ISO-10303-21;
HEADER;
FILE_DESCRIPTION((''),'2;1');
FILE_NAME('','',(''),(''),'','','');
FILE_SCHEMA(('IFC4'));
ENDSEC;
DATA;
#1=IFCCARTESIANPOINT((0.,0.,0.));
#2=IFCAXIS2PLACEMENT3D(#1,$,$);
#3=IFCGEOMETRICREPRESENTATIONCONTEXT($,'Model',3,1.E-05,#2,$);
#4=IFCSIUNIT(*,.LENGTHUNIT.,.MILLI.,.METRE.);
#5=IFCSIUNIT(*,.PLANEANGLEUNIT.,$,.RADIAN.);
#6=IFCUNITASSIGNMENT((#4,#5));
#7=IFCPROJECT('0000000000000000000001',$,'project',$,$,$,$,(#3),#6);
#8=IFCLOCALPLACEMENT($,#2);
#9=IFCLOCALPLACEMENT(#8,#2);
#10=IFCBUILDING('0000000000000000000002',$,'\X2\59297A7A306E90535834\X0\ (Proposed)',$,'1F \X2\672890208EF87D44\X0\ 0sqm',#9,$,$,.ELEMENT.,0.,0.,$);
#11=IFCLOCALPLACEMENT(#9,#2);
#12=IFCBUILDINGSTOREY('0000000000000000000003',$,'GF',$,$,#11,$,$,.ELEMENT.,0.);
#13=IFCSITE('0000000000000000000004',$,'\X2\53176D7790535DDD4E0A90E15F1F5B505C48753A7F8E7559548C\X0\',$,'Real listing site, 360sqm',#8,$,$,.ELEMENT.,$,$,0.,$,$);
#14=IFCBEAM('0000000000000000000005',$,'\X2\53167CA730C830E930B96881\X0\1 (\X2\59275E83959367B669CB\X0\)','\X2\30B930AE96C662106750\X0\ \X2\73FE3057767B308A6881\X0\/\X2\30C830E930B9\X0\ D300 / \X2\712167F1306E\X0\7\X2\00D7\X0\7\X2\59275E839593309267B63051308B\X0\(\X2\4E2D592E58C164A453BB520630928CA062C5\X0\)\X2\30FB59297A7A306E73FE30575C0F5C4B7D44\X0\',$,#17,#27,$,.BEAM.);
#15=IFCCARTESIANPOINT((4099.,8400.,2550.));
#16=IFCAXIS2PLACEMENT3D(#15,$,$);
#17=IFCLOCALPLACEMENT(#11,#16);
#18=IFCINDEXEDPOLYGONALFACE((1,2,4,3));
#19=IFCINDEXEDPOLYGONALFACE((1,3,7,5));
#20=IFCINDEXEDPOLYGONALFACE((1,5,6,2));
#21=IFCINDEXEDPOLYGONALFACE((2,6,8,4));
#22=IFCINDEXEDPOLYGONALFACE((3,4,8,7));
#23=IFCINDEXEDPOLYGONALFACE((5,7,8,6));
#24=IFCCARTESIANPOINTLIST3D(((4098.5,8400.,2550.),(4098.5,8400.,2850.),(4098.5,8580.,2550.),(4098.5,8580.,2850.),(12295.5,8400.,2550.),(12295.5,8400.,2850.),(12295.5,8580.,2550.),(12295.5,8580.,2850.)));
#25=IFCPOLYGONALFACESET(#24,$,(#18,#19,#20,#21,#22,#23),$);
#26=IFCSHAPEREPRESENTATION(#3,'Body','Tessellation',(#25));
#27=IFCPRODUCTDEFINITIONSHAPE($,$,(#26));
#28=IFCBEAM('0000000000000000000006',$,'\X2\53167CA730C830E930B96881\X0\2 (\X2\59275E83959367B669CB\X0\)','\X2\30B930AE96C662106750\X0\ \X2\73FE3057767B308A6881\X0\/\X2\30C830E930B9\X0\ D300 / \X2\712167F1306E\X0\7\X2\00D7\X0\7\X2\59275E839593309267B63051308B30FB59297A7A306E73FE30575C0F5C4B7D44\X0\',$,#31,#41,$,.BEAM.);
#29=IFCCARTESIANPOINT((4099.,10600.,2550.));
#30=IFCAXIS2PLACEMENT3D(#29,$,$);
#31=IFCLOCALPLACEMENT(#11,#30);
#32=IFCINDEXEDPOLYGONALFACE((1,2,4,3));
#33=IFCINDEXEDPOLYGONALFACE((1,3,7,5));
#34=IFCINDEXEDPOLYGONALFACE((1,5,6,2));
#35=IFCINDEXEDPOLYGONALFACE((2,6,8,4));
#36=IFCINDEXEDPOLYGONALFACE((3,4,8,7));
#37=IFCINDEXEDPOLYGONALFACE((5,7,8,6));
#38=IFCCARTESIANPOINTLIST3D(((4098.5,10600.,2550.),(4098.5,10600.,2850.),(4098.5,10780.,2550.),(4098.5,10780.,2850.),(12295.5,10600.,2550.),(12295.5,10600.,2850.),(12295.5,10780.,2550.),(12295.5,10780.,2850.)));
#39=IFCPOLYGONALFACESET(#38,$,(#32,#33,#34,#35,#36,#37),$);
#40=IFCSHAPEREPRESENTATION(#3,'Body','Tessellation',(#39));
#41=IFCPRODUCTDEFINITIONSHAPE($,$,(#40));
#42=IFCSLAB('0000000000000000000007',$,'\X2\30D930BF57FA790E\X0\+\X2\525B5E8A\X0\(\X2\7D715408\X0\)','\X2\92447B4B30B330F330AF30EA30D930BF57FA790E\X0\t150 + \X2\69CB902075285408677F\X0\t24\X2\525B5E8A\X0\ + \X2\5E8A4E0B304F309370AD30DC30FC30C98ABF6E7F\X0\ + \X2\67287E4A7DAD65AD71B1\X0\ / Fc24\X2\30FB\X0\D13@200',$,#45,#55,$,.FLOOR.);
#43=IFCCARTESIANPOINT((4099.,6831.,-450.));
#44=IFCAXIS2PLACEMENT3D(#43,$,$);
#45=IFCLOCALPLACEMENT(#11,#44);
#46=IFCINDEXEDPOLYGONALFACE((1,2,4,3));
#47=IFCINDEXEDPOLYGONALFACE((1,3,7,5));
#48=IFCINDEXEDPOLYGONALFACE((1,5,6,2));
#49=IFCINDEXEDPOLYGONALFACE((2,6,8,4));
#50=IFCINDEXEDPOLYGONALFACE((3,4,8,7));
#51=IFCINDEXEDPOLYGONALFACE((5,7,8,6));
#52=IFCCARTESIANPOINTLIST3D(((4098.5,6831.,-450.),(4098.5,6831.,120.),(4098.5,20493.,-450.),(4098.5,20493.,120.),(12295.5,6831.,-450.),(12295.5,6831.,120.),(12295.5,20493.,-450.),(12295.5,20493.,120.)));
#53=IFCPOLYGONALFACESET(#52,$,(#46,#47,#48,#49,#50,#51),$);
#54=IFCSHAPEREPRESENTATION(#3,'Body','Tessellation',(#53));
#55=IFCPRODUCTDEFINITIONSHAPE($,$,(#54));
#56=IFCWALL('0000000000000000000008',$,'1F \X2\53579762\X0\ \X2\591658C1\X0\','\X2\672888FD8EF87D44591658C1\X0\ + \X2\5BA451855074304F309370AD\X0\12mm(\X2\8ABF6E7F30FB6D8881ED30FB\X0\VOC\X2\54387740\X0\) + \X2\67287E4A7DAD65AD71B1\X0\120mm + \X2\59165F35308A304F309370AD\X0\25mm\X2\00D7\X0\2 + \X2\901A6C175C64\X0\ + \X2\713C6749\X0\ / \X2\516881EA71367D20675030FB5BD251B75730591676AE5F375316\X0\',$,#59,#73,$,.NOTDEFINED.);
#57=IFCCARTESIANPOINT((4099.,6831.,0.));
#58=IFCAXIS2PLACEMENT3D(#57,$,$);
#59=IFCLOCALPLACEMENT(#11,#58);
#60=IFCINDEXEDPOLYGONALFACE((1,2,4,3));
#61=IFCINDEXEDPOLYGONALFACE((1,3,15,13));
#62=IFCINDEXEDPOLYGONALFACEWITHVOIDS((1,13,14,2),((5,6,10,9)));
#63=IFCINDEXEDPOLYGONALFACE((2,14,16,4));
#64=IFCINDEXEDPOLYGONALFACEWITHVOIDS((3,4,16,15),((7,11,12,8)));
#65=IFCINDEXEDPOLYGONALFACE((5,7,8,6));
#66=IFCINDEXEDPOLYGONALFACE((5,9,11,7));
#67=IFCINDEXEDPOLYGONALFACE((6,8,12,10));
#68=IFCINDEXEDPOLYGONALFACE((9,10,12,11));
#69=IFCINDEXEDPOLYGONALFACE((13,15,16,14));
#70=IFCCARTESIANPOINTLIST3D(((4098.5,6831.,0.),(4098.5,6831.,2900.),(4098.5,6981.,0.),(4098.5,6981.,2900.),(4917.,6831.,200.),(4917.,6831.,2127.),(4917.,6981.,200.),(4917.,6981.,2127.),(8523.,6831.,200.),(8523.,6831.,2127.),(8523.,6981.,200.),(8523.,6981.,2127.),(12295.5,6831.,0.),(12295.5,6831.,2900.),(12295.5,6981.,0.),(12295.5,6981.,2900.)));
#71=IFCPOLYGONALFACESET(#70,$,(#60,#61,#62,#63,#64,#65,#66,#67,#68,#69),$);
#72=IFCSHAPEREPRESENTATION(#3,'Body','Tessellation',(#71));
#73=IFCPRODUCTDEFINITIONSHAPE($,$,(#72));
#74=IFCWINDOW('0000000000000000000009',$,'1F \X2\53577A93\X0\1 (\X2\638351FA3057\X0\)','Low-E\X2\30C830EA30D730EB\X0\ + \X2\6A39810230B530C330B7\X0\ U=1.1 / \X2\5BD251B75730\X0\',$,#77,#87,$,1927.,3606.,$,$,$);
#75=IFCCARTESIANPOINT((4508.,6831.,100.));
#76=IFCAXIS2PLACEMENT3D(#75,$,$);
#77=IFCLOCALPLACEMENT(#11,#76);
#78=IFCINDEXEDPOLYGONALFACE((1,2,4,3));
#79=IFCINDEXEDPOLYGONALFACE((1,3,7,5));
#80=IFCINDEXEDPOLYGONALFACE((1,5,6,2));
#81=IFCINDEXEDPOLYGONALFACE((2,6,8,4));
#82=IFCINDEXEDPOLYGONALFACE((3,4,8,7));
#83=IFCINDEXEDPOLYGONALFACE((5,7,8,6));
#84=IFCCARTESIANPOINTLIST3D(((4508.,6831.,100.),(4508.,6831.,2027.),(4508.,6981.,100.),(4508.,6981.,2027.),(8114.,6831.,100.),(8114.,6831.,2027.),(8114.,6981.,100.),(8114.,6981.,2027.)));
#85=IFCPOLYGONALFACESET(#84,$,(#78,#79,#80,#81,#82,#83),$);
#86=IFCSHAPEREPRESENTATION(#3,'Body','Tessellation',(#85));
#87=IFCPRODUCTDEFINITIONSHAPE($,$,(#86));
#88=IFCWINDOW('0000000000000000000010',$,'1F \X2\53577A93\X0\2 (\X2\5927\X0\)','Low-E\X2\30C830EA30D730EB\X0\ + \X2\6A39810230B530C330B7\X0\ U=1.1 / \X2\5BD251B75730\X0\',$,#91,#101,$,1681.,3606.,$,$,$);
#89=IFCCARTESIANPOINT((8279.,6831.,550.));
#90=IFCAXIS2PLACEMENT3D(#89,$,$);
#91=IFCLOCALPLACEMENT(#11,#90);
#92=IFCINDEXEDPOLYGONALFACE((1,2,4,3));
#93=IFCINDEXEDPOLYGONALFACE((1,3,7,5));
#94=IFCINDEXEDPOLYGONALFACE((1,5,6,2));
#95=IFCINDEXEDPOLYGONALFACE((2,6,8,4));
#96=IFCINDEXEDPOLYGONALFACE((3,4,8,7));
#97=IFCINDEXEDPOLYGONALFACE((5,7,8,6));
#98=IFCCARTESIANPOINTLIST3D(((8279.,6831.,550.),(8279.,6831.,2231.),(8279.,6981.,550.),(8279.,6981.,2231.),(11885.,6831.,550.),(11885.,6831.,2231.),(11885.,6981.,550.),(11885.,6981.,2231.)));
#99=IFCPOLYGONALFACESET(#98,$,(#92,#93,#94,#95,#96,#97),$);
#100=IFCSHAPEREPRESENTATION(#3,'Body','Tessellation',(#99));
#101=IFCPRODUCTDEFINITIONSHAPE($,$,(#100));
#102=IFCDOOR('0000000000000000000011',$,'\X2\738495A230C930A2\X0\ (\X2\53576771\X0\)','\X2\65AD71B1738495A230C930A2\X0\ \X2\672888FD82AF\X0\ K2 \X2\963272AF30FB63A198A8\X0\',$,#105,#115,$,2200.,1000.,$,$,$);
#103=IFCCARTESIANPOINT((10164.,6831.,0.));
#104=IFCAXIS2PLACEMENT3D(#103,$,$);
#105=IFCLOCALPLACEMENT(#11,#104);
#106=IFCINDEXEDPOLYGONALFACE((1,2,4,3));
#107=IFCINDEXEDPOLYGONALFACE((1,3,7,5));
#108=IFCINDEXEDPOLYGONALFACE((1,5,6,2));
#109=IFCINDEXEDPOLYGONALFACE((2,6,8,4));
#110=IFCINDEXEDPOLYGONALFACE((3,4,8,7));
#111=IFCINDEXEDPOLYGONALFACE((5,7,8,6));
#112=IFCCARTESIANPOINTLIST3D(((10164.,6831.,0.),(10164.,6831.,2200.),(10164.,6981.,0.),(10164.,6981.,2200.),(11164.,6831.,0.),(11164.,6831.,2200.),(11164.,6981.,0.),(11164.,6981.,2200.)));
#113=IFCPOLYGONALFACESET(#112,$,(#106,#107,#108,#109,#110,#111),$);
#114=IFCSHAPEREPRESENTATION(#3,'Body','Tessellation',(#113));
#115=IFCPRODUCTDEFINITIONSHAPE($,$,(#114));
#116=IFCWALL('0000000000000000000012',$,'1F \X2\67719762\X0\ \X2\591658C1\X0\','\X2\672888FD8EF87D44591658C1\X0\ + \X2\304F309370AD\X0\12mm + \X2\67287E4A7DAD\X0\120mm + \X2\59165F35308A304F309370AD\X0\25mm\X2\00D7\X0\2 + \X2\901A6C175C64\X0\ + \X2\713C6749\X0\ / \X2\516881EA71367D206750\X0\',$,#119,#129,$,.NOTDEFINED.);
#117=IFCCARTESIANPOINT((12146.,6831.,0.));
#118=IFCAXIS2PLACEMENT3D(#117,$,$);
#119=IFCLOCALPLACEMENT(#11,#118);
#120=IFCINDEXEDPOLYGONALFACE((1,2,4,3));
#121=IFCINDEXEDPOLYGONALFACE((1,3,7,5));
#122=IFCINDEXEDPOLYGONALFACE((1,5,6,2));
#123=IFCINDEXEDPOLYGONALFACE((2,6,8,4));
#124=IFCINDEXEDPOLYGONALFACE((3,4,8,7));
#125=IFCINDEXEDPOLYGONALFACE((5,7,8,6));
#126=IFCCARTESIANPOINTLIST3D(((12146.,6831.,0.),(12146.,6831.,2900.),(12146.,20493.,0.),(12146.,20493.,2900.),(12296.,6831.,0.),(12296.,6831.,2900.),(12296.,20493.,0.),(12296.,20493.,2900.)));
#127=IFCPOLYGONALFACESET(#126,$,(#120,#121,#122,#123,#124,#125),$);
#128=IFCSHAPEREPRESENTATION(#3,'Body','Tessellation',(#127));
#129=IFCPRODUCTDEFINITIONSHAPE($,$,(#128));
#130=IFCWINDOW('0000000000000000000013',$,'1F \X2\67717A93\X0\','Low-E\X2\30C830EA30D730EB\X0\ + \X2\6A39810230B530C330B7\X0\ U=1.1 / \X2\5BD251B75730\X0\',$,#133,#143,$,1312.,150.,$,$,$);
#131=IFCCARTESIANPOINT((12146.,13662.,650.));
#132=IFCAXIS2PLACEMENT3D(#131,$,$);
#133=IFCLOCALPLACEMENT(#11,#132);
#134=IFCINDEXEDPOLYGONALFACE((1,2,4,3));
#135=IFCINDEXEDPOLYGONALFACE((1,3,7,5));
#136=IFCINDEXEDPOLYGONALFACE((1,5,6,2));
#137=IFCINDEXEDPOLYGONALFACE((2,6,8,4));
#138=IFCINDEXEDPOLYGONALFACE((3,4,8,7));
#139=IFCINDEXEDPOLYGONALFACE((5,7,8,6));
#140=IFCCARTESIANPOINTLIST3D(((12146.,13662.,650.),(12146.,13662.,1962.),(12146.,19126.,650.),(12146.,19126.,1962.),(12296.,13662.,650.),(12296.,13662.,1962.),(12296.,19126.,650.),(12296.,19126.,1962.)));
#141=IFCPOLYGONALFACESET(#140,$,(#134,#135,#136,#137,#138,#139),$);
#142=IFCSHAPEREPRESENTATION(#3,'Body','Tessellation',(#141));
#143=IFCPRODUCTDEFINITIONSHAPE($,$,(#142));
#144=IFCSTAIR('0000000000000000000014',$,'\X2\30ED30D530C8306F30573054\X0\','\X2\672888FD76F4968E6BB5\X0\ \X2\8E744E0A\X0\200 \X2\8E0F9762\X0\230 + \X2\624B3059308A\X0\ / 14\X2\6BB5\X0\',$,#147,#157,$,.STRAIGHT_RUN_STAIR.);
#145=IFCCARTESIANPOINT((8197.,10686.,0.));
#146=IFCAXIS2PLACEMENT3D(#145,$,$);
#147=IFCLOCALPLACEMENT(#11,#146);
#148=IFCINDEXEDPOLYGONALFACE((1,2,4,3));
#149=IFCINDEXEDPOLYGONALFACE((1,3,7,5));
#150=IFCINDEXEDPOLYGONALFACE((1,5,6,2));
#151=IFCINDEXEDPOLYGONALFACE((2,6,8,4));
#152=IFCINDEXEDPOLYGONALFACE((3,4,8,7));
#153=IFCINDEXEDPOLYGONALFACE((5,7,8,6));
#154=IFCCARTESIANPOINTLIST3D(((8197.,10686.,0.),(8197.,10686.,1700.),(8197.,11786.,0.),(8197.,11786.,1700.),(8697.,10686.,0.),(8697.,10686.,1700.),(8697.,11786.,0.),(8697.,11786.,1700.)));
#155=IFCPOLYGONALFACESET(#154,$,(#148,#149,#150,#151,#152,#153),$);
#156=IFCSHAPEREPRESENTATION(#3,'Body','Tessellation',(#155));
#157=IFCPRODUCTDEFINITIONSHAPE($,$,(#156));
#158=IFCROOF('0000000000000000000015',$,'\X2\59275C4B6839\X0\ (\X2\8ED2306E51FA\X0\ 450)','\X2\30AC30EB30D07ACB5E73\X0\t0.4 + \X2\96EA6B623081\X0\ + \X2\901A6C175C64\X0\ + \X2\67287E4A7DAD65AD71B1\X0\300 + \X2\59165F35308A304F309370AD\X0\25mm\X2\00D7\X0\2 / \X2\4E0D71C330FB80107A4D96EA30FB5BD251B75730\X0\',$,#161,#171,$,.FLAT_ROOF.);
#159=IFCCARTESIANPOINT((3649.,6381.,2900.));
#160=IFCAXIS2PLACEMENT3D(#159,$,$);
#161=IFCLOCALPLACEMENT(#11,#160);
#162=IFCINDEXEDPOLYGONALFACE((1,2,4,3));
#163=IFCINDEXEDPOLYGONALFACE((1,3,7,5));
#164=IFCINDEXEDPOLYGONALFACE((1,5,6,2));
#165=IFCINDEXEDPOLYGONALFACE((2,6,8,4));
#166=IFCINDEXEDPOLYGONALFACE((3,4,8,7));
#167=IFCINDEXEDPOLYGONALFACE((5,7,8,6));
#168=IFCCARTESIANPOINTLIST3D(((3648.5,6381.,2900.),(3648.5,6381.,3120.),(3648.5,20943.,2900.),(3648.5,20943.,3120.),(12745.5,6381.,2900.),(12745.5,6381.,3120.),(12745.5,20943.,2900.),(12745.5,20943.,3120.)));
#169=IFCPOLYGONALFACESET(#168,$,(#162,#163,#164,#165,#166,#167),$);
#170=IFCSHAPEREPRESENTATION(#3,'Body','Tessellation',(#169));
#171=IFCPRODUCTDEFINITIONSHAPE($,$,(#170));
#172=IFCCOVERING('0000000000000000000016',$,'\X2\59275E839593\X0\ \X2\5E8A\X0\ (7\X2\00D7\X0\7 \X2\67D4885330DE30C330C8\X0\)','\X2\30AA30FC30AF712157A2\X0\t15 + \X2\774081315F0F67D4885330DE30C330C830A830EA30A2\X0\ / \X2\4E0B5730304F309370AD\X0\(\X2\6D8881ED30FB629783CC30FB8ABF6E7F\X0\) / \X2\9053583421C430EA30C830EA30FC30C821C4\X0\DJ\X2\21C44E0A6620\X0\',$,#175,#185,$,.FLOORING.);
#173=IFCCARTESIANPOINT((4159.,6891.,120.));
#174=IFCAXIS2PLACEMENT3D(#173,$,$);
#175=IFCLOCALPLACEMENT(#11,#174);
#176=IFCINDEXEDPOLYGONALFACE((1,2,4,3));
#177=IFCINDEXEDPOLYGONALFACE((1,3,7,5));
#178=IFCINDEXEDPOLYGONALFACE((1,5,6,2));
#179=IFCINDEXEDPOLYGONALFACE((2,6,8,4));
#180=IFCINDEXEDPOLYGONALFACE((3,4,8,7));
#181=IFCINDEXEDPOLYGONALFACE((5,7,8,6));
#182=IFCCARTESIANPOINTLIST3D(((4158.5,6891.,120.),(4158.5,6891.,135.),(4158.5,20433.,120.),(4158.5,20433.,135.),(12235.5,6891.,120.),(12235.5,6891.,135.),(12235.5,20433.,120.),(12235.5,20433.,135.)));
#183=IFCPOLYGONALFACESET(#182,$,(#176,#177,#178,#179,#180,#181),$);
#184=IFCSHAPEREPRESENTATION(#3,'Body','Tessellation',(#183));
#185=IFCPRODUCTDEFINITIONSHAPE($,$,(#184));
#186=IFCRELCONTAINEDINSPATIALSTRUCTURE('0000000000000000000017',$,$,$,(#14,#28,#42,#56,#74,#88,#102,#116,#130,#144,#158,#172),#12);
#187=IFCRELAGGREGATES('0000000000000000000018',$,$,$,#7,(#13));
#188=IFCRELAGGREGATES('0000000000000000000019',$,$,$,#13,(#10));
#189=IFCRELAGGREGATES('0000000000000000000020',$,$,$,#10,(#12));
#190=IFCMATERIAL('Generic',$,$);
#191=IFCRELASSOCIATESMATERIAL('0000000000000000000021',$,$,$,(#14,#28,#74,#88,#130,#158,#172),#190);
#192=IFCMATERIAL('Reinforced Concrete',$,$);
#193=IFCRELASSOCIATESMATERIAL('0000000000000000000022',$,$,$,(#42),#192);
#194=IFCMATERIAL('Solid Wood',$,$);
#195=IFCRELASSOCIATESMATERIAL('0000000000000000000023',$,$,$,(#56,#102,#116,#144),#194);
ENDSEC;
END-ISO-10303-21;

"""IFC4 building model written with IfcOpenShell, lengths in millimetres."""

from ifc_helpers import new_model, si_unit, frame, frame_2d, origin, place, context, project, spatial, rectangle, extrude, material, element, fill, save


model = new_model("IFC4")

# Units and contexts
model_context = context("Model", 3, precision=1e-05, world=origin())
ifc_project = project(units=[si_unit("LENGTHUNIT", "METRE", prefix="MILLI"), si_unit("PLANEANGLEUNIT", "RADIAN")], contexts=[model_context])

# Site, building, storey
site_placement = place(None, origin())
site = spatial("IfcSite", under=ifc_project, at=site_placement, Name="北海道川上郡弟子屈町美留和", ObjectType="Real listing site, 360sqm", CompositionType="ELEMENT", RefElevation=0.0)
building_placement = place(site_placement, origin())
building = spatial("IfcBuilding", under=site, at=building_placement, Name="天空の道場 (Proposed)", ObjectType="1F 木造軸組 0sqm", CompositionType="ELEMENT", ElevationOfRefHeight=0.0, ElevationOfTerrain=0.0)
storey_placement = place(building_placement, origin())
storey = spatial("IfcBuildingStorey", under=building, at=storey_placement, Name="GF", CompositionType="ELEMENT", Elevation=0.0)

# Beams
ifc_material_1 = material(Name="Generic")
beam_1_placement = place(storey_placement, frame((4099.0, 8400.0, 2550.0)))
element("IfcBeam", 1, at=beam_1_placement, inside=storey, material=ifc_material_1, Name="化粧トラス梁1 (大広間架構)", Description="スギ集成材 現し登り梁/トラス D300 / 無柱の7×7大広間を架ける(中央壁撤去分を負担)・天空の現し小屋組", PredefinedType="BEAM", context=model_context, shape_type="SweptSolid", body=[
    extrude(rectangle(XDim=8197.0, YDim=180.0, at=frame_2d((4098.0, 90.0))), frame((4099.0, 8400.0, 2550.0)), (0.0, 0.0, 1.0), 300.0),
])
beam_2_placement = place(storey_placement, frame((4099.0, 10600.0, 2550.0)))
element("IfcBeam", 2, at=beam_2_placement, inside=storey, material=ifc_material_1, Name="化粧トラス梁2 (大広間架構)", Description="スギ集成材 現し登り梁/トラス D300 / 無柱の7×7大広間を架ける・天空の現し小屋組", PredefinedType="BEAM", context=model_context, shape_type="SweptSolid", body=[
    extrude(rectangle(XDim=8197.0, YDim=180.0, at=frame_2d((4098.0, 90.0))), frame((4099.0, 10600.0, 2550.0)), (0.0, 0.0, 1.0), 300.0),
])

# Slab
ifc_material_2 = material(Name="Reinforced Concrete")
slab_1_placement = place(storey_placement, frame((4099.0, 6831.0, -450.0)))
element("IfcSlab", 3, at=slab_1_placement, inside=storey, material=ifc_material_2, Name="ベタ基礎+剛床(統合)", Description="鉄筋コンクリベタ基礎t150 + 構造用合板t24剛床 + 床下くん炭ボード調湿 + 木繊維断熱 / Fc24・D13@200", PredefinedType="FLOOR", context=model_context, shape_type="SweptSolid", body=[
    extrude(rectangle(XDim=8197.0, YDim=13662.0, at=frame_2d((4098.0, 6831.0))), frame((4099.0, 6831.0, -450.0)), (0.0, 0.0, 1.0), 570.0),
])

# Wall, openings, windows, door
ifc_material_3 = material(Name="Solid Wood")
wall_1_placement = place(storey_placement, frame((4099.0, 6831.0, 0.0)))
wall_1 = element("IfcWall", 4, at=wall_1_placement, inside=storey, material=ifc_material_3, Name="1F 南面 外壁", Description="木製軸組外壁 + 室内側くん炭12mm(調湿・消臭・VOC吸着) + 木繊維断熱120mm + 外張りくん炭25mm×2 + 通気層 + 焼杉 / 全自然素材・寒冷地外皮強化", PredefinedType="NOTDEFINED", context=model_context, shape_type="SweptSolid", body=[
    extrude(rectangle(XDim=8197.0, YDim=150.0, at=frame_2d((4098.0, 75.0))), frame((4099.0, 6831.0, 0.0)), (0.0, 0.0, 1.0), 2900.0),
])
opening_1_placement = place(storey_placement, frame((4508.0, 6831.0, 100.0)))
opening_1 = element("IfcOpeningElement", 5, at=opening_1_placement, cuts=wall_1, PredefinedType="NOTDEFINED", context=model_context, shape_type="SweptSolid", body=[
    extrude(rectangle(XDim=3606.0, YDim=150.0, at=frame_2d((1803.0, 75.0))), frame((4508.0, 6831.0, 100.0)), (0.0, 0.0, 1.0), 1927.0),
])
opening_2_placement = place(storey_placement, frame((8279.0, 6831.0, 550.0)))
opening_2 = element("IfcOpeningElement", 6, at=opening_2_placement, cuts=wall_1, PredefinedType="NOTDEFINED", context=model_context, shape_type="SweptSolid", body=[
    extrude(rectangle(XDim=3606.0, YDim=150.0, at=frame_2d((1803.0, 75.0))), frame((8279.0, 6831.0, 550.0)), (0.0, 0.0, 1.0), 1681.0),
])
opening_3_placement = place(storey_placement, frame((10164.0, 6831.0, 0.0)))
opening_3 = element("IfcOpeningElement", 7, at=opening_3_placement, cuts=wall_1, PredefinedType="NOTDEFINED", context=model_context, shape_type="SweptSolid", body=[
    extrude(rectangle(XDim=1000.0, YDim=150.0, at=frame_2d((500.0, 75.0))), frame((10164.0, 6831.0, 0.0)), (0.0, 0.0, 1.0), 2200.0),
])
window_1_placement = place(storey_placement, frame((4508.0, 6831.0, 100.0)))
window_1 = element("IfcWindow", 8, at=window_1_placement, inside=storey, material=ifc_material_1, Name="1F 南窓1 (掃出し)", Description="Low-Eトリプル + 樹脂サッシ U=1.1 / 寒冷地", OverallHeight=1927.0, OverallWidth=3606.0, context=model_context, shape_type="SweptSolid", body=[
    extrude(rectangle(XDim=3606.0, YDim=150.0, at=frame_2d((1803.0, 75.0))), frame((4508.0, 6831.0, 100.0)), (0.0, 0.0, 1.0), 1927.0),
])
fill(opening_1, window_1)
window_2_placement = place(storey_placement, frame((8279.0, 6831.0, 550.0)))
window_2 = element("IfcWindow", 9, at=window_2_placement, inside=storey, material=ifc_material_1, Name="1F 南窓2 (大)", Description="Low-Eトリプル + 樹脂サッシ U=1.1 / 寒冷地", OverallHeight=1681.0, OverallWidth=3606.0, context=model_context, shape_type="SweptSolid", body=[
    extrude(rectangle(XDim=3606.0, YDim=150.0, at=frame_2d((1803.0, 75.0))), frame((8279.0, 6831.0, 550.0)), (0.0, 0.0, 1.0), 1681.0),
])
fill(opening_2, window_2)
door_placement = place(storey_placement, frame((10164.0, 6831.0, 0.0)))
door = element("IfcDoor", 10, at=door_placement, inside=storey, material=ifc_material_3, Name="玄関ドア (南東)", Description="断熱玄関ドア 木製芯 K2 防犯・採風", OverallHeight=2200.0, OverallWidth=1000.0, context=model_context, shape_type="SweptSolid", body=[
    extrude(rectangle(XDim=1000.0, YDim=150.0, at=frame_2d((500.0, 75.0))), frame((10164.0, 6831.0, 0.0)), (0.0, 0.0, 1.0), 2200.0),
])
fill(opening_3, door)

# Wall, opening, window
wall_2_placement = place(storey_placement, frame((12146.0, 6831.0, 0.0)))
wall_2 = element("IfcWall", 11, at=wall_2_placement, inside=storey, material=ifc_material_3, Name="1F 東面 外壁", Description="木製軸組外壁 + くん炭12mm + 木繊維120mm + 外張りくん炭25mm×2 + 通気層 + 焼杉 / 全自然素材", PredefinedType="NOTDEFINED", context=model_context, shape_type="SweptSolid", body=[
    extrude(rectangle(XDim=150.0, YDim=13662.0, at=frame_2d((75.0, 6831.0))), frame((12146.0, 6831.0, 0.0)), (0.0, 0.0, 1.0), 2900.0),
])
opening_4_placement = place(storey_placement, frame((12146.0, 13662.0, 650.0)))
opening_4 = element("IfcOpeningElement", 12, at=opening_4_placement, cuts=wall_2, PredefinedType="NOTDEFINED", context=model_context, shape_type="SweptSolid", body=[
    extrude(rectangle(XDim=150.0, YDim=5464.0, at=frame_2d((75.0, 2732.0))), frame((12146.0, 13662.0, 650.0)), (0.0, 0.0, 1.0), 1312.0),
])
window_3_placement = place(storey_placement, frame((12146.0, 13662.0, 650.0)))
window_3 = element("IfcWindow", 13, at=window_3_placement, inside=storey, material=ifc_material_1, Name="1F 東窓", Description="Low-Eトリプル + 樹脂サッシ U=1.1 / 寒冷地", OverallHeight=1312.0, OverallWidth=150.0, context=model_context, shape_type="SweptSolid", body=[
    extrude(rectangle(XDim=150.0, YDim=5464.0, at=frame_2d((75.0, 2732.0))), frame((12146.0, 13662.0, 650.0)), (0.0, 0.0, 1.0), 1312.0),
])
fill(opening_4, window_3)

# Stair
stair_placement = place(storey_placement, frame((8197.0, 10686.0, 0.0)))
element("IfcStair", 14, at=stair_placement, inside=storey, material=ifc_material_3, Name="ロフトはしご", Description="木製直階段 蹴上200 踏面230 + 手すり / 14段", PredefinedType="STRAIGHT_RUN_STAIR", context=model_context, shape_type="SweptSolid", body=[
    extrude(rectangle(XDim=500.0, YDim=1100.0, at=frame_2d((250.0, 550.0))), frame((8197.0, 10686.0, 0.0)), (0.0, 0.0, 1.0), 1700.0),
])

# Roof
roof_placement = place(storey_placement, frame((3649.0, 6381.0, 2900.0)))
element("IfcRoof", 15, at=roof_placement, inside=storey, material=ifc_material_1, Name="大屋根 (軒の出 450)", Description="ガルバ立平t0.4 + 雪止め + 通気層 + 木繊維断熱300 + 外張りくん炭25mm×2 / 不燃・耐積雪・寒冷地", PredefinedType="FLAT_ROOF", context=model_context, shape_type="SweptSolid", body=[
    extrude(rectangle(XDim=9097.0, YDim=14562.0, at=frame_2d((4548.0, 7281.0))), frame((3649.0, 6381.0, 2900.0)), (0.0, 0.0, 1.0), 220.0),
])

# Covering
covering_placement = place(storey_placement, frame((4159.0, 6891.0, 120.0)))
element("IfcCovering", 16, at=covering_placement, inside=storey, material=ifc_material_1, Name="大広間 床 (7×7 柔術マット)", Description="オーク無垢t15 + 着脱式柔術マットエリア / 下地くん炭(消臭・抗菌・調湿) / 道場⇄リトリート⇄DJ⇄上映", PredefinedType="FLOORING", context=model_context, shape_type="SweptSolid", body=[
    extrude(rectangle(XDim=8077.0, YDim=13542.0, at=frame_2d((4038.0, 6771.0))), frame((4159.0, 6891.0, 120.0)), (0.0, 0.0, 1.0), 15.0),
])

save(model, "model.ifc")
